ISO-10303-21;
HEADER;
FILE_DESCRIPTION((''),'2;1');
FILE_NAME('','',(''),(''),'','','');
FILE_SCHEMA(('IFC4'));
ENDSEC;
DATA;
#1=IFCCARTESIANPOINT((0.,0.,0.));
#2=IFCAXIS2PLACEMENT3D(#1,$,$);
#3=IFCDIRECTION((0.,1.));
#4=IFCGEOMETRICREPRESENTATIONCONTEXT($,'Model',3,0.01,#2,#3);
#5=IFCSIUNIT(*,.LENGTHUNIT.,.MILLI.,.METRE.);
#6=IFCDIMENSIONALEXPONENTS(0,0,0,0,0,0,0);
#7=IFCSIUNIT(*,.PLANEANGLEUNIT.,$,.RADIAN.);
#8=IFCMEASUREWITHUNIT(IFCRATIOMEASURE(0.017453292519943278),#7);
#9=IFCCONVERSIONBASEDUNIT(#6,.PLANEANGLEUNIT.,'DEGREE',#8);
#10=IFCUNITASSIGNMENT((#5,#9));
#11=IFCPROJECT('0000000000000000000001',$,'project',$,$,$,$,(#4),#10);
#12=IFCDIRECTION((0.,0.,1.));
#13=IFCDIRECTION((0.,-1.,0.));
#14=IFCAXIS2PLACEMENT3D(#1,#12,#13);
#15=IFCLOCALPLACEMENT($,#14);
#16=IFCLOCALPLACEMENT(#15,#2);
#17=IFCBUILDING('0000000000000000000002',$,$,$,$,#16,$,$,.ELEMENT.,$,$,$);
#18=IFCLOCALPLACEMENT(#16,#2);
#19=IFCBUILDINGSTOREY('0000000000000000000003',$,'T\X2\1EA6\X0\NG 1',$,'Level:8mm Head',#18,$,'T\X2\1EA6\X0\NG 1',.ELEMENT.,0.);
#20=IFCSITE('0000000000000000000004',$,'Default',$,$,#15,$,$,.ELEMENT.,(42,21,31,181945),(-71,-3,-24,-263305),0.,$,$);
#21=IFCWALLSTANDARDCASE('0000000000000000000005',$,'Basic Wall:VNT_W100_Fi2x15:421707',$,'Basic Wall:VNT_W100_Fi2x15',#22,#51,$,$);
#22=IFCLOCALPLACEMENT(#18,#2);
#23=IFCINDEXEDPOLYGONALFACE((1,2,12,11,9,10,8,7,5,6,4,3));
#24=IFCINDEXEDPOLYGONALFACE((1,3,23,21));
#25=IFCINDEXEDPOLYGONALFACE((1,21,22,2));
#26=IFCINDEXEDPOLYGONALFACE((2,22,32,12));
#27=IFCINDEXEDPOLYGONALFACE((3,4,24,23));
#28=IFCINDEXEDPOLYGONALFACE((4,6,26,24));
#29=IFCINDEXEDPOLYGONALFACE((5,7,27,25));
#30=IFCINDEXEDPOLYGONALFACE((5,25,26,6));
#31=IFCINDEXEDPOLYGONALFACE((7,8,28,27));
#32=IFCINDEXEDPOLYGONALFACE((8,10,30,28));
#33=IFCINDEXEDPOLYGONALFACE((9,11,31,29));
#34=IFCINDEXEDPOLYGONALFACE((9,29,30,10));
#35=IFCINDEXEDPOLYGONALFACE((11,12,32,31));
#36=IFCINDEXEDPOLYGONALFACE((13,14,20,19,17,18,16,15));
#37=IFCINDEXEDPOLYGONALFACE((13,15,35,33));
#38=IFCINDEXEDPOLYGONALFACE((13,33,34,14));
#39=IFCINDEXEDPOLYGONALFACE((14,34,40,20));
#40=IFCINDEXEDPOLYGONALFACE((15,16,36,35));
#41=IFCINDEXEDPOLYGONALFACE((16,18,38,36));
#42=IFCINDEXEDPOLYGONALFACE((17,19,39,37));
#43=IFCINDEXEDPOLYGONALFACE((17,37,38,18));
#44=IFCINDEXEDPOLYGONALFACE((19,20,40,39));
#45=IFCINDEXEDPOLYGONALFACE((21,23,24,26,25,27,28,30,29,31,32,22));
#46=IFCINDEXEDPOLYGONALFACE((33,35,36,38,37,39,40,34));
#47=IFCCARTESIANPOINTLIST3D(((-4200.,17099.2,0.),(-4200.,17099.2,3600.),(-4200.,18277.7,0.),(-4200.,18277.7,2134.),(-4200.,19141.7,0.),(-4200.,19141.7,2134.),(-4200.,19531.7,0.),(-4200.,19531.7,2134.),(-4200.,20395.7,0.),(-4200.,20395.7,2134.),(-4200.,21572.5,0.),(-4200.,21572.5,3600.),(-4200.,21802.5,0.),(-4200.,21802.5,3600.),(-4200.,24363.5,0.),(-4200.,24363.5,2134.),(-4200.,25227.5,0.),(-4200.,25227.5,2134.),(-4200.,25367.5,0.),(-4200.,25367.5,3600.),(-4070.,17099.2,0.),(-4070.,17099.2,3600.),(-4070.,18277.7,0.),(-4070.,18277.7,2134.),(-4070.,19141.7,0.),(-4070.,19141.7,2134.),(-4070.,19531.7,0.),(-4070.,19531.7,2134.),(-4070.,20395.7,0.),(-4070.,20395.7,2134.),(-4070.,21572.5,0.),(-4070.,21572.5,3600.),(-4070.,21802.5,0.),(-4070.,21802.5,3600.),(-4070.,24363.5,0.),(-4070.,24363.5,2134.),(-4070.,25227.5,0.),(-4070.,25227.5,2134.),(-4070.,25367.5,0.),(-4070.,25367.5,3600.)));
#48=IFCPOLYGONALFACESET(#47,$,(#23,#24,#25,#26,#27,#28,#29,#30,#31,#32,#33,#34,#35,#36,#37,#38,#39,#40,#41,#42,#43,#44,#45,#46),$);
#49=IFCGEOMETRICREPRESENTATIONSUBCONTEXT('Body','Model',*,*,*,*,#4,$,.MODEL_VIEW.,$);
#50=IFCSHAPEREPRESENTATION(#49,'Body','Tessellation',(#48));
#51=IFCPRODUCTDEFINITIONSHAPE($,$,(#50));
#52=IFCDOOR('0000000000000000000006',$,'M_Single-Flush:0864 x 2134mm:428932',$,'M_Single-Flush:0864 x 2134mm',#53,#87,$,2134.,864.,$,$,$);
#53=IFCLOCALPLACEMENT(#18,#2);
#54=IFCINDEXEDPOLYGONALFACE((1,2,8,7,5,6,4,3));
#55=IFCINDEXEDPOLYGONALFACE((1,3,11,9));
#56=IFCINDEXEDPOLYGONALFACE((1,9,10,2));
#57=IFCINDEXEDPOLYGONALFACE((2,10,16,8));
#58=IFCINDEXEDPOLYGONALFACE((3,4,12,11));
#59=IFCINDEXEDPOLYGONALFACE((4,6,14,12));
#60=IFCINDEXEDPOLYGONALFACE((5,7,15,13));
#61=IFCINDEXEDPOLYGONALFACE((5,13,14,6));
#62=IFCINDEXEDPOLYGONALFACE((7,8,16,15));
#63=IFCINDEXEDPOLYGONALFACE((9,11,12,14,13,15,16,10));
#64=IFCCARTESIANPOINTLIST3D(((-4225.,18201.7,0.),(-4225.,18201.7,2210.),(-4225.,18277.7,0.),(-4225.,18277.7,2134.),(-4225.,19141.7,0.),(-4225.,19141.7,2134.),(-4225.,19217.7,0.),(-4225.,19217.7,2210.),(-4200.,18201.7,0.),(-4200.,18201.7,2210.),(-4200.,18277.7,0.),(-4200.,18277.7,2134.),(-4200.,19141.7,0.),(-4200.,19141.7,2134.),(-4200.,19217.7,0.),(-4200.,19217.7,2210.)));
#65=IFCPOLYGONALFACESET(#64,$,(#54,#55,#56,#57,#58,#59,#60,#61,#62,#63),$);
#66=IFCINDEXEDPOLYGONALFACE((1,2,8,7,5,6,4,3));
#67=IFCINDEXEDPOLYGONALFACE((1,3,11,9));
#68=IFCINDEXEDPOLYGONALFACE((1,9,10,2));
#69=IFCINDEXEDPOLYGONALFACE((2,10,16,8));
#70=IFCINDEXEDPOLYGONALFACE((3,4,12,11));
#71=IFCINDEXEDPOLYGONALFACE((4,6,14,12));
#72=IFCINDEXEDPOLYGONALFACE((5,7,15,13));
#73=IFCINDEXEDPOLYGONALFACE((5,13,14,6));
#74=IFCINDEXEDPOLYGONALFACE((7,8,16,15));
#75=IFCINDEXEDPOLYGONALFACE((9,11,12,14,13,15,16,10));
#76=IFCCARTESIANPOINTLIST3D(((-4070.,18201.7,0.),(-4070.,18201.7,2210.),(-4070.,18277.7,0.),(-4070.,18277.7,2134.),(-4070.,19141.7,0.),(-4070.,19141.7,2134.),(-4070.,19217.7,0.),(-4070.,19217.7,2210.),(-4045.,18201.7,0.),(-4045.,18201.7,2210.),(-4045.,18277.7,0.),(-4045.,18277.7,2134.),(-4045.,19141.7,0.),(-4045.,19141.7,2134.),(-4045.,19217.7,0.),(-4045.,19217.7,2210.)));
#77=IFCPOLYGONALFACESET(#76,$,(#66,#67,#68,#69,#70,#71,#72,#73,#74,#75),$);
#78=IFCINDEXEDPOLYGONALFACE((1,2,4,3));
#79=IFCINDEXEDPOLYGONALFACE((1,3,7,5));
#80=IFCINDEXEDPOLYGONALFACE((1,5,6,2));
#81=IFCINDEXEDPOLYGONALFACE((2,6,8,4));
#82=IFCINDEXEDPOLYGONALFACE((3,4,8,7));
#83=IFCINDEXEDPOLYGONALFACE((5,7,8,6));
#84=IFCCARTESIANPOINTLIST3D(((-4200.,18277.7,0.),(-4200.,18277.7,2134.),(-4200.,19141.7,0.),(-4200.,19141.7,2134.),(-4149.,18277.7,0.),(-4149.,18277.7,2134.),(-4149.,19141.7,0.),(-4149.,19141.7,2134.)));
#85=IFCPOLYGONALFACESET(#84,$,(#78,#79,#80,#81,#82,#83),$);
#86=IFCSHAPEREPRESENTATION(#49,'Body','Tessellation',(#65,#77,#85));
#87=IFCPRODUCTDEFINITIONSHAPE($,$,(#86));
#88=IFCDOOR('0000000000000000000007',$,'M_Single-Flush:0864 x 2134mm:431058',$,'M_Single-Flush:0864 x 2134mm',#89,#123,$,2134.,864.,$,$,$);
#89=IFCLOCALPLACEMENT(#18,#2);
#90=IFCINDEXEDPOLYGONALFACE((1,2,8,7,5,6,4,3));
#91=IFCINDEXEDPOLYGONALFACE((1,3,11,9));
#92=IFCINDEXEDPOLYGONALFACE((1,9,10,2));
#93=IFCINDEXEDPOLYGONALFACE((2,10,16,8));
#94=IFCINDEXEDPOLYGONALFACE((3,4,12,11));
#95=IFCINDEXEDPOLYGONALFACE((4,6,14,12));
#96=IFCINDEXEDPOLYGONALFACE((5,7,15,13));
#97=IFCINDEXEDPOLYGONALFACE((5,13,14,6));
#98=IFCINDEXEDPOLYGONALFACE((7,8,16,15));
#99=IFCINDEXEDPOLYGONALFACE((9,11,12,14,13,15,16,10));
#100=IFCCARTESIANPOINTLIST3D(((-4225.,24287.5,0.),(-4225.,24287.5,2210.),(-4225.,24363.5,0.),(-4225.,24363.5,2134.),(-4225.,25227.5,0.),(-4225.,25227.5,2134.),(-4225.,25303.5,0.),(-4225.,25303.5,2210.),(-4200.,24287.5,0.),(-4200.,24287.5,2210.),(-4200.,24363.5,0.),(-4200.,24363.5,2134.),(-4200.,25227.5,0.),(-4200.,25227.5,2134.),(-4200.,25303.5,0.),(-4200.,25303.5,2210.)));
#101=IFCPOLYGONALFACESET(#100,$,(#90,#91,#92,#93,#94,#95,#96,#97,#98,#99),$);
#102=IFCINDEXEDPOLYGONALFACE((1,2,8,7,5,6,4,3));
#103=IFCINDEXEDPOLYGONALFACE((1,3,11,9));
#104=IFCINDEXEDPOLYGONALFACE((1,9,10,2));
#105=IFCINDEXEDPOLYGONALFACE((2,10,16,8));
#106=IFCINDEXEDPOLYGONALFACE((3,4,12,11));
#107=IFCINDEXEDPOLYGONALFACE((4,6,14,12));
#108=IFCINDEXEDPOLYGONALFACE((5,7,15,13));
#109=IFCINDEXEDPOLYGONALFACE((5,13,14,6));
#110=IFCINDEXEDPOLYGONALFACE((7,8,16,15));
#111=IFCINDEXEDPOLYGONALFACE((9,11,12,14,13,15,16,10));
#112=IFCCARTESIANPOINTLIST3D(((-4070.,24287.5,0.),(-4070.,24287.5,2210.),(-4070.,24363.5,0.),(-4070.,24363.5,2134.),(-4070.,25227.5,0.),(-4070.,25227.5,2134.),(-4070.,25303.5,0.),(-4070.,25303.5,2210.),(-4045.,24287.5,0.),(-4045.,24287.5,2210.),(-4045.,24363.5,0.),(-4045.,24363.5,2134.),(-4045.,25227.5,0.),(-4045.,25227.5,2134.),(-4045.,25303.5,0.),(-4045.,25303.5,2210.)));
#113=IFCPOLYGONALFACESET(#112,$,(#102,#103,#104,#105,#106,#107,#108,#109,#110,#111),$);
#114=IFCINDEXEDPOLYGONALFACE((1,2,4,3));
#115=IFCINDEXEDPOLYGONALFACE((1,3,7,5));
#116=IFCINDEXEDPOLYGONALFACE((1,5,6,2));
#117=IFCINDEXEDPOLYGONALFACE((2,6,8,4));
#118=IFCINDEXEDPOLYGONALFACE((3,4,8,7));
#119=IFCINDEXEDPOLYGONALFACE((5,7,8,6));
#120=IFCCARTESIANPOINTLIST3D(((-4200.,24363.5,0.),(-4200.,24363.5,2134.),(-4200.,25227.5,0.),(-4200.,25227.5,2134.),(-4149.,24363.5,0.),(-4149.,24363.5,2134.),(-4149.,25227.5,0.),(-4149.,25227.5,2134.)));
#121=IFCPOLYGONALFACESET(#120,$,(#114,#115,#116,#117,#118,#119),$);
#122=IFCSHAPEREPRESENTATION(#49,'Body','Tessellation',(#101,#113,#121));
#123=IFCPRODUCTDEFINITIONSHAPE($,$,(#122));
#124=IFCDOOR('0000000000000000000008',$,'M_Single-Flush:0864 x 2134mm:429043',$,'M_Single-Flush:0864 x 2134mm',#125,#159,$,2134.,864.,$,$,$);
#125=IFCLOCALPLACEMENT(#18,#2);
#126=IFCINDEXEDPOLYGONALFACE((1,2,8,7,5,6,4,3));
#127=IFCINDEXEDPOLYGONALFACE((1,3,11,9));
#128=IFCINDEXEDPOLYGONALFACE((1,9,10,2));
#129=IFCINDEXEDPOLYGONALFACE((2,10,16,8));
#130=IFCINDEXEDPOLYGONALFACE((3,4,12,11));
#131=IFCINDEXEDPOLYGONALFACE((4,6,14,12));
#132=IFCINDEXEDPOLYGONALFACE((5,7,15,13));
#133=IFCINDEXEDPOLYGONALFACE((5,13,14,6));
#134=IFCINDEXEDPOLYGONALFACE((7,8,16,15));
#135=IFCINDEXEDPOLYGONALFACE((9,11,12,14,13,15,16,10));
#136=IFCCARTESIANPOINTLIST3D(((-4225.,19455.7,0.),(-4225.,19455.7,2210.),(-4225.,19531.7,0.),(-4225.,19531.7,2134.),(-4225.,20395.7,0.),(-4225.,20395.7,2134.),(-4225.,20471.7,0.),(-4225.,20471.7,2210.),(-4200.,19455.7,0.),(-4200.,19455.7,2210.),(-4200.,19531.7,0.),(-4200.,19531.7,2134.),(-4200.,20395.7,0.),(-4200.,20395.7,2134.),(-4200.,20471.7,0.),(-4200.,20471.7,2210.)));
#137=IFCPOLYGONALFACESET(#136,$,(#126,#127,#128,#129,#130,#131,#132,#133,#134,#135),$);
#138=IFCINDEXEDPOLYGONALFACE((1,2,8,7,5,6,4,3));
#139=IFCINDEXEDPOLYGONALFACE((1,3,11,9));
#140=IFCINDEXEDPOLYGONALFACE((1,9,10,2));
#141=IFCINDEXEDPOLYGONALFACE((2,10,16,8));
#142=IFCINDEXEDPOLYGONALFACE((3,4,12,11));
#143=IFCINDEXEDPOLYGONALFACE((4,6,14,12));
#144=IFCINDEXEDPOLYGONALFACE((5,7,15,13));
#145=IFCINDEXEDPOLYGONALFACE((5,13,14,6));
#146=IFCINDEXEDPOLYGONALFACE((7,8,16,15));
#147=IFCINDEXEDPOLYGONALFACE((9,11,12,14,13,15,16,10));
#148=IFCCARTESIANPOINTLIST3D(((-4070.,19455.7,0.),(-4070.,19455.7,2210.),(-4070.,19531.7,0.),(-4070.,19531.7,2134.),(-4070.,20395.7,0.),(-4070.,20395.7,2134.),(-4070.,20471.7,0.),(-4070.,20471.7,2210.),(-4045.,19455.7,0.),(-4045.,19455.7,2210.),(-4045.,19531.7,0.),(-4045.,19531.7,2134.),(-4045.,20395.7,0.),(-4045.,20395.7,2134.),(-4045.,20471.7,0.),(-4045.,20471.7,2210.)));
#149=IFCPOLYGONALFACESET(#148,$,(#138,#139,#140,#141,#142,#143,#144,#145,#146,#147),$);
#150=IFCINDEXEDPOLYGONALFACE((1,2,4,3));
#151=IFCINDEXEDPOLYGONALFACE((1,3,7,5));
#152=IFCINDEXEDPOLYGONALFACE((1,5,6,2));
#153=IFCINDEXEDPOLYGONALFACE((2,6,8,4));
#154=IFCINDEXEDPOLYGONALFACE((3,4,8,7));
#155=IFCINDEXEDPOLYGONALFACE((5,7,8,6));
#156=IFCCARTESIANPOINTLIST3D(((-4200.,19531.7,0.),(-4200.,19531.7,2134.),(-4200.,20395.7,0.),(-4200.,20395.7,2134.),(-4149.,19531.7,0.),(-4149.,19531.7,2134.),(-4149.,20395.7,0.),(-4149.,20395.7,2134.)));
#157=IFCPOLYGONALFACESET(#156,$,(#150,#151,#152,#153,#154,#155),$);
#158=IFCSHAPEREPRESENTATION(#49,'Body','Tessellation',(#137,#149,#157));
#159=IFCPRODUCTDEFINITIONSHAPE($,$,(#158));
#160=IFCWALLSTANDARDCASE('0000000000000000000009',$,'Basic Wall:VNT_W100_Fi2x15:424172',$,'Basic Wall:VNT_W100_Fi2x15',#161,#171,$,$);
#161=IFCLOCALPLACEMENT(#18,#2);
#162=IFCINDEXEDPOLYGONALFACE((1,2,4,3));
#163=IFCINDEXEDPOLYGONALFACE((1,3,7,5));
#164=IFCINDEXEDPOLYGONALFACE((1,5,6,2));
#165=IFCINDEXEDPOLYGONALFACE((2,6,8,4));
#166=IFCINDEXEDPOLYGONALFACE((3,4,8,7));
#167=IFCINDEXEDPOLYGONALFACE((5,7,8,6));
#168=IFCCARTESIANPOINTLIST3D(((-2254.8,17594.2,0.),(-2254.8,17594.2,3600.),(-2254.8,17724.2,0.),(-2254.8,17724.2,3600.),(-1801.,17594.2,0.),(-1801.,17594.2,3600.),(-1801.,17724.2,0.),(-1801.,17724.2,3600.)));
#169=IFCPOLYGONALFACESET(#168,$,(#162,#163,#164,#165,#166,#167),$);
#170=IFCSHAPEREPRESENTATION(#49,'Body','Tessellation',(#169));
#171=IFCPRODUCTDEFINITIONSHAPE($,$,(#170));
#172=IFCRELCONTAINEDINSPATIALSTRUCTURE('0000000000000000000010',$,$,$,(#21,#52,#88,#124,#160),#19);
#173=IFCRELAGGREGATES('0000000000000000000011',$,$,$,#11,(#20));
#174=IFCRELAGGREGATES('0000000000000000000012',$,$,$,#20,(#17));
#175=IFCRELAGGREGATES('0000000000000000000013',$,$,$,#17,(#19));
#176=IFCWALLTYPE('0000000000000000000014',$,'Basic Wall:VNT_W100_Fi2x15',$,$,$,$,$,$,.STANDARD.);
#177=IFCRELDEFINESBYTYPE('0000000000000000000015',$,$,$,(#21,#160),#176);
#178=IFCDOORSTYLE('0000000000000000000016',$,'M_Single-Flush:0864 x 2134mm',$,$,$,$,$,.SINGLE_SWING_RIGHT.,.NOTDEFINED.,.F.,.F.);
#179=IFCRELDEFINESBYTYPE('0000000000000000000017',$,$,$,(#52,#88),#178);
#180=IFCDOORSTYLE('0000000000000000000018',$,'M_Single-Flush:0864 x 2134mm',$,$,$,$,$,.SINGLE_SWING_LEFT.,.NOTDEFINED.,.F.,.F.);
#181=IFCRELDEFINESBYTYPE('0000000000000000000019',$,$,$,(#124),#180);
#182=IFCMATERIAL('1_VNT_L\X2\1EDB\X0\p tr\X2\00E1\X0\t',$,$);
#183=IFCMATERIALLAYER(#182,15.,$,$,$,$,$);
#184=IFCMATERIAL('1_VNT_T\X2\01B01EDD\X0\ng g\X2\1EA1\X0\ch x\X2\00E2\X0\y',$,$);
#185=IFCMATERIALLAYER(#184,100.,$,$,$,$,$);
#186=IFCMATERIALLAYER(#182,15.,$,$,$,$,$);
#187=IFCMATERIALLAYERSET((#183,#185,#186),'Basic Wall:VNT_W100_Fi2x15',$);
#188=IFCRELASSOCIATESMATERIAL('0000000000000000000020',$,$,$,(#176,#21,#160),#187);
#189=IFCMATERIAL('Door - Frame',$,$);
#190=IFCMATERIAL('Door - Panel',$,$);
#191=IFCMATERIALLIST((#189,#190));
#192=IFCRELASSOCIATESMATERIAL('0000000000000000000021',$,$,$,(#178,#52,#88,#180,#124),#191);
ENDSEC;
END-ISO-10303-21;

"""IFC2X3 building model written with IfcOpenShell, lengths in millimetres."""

from ifc_helpers import new_model, entity, si_unit, converted_unit, direction, frame, frame_2d, origin, place, context, subcontext, project, spatial, polyline, rectangle, outline, extrude, source, transform, mapped, material, material_list, layer, layer_set, layer_usage, type_object, type_shapes, element, fill, save


model = new_model("IFC2X3")

# Units and contexts
model_context = context("Model", 3, precision=0.01, world=origin(), true_north=direction((0.0, 1.0)))
body_context = subcontext(model_context, "Body", "Model", "MODEL_VIEW")
ifc_project = project(units=[si_unit("LENGTHUNIT", "METRE", prefix="MILLI"), converted_unit("PLANEANGLEUNIT", "DEGREE", entity("IfcRatioMeasure", 0.017453292519943278), si_unit("PLANEANGLEUNIT", "RADIAN"), dimensions=[0, 0, 0, 0, 0, 0, 0])], contexts=[model_context])

# Site, building, storey
site_placement = place(None, frame((0.0, 0.0, 0.0), z_axis=(0.0, 0.0, 1.0), x_axis=(0.0, -1.0, 0.0)))
site = spatial("IfcSite", under=ifc_project, at=site_placement, Name="Default", CompositionType="ELEMENT", RefLatitude=(42, 21, 31, 181945), RefLongitude=(-71, -3, -24, -263305), RefElevation=0.0)
building_placement = place(site_placement, origin())
building = spatial("IfcBuilding", under=site, at=building_placement, CompositionType="ELEMENT")
storey_placement = place(building_placement, origin())
storey = spatial("IfcBuildingStorey", under=building, at=storey_placement, Name="TẦNG 1", ObjectType="Level:8mm Head", LongName="TẦNG 1", CompositionType="ELEMENT", Elevation=0.0)

# Shared definitions
ifc_material_1 = material(Name="1_VNT_Lớp trát")
ifc_material_2 = material(Name="1_VNT_Tường gạch xây")

# Shared definitions
ifc_layer_1 = layer(ifc_material_1, 15.0)
ifc_layer_2 = layer(ifc_material_2, 100.0)
ifc_layer_3 = layer(ifc_material_1, 15.0)
ifc_layer_set_1 = layer_set([ifc_layer_1, ifc_layer_2, ifc_layer_3], Name="Basic Wall:VNT_W100_Fi2x15")
ifc_layer_usage_1 = layer_usage(ifc_layer_set_1, "AXIS2", "NEGATIVE", 65.0)
wall_type_1 = type_object("IfcWallType", Name="Basic Wall:VNT_W100_Fi2x15", PredefinedType="STANDARD", material=ifc_layer_set_1)

# Wall, openings, doors
wall_1_placement = place(storey_placement, frame((-4135.0, 17099.2, 0.0), z_axis=(0.0, 0.0, 1.0), x_axis=(0.0, 1.0, 0.0)))
wall_1 = element("IfcWallStandardCase", 1, at=wall_1_placement, inside=storey, type_object=wall_type_1, material=ifc_layer_usage_1, Name="Basic Wall:VNT_W100_Fi2x15:421707", ObjectType="Basic Wall:VNT_W100_Fi2x15", context=body_context, shape_type="SweptSolid", body=[
    extrude(rectangle(XDim=8268.3, YDim=130.0, at=frame_2d((4134.1, 0.0), x_axis=(-1.0, 0.0))), origin(), (0.0, 0.0, 1.0), 3600.0),
])
opening_1_placement = place(storey_placement, frame((-4135.0, 17099.2, 0.0), z_axis=(0.0, 0.0, 1.0), x_axis=(0.0, 1.0, 0.0)))
element("IfcOpeningElement", 2, at=opening_1_placement, cuts=wall_1, ObjectType="Opening", context=body_context, shape_type="SweptSolid", body=[
    extrude(rectangle(XDim=3600.0, YDim=130.0, at=frame_2d((0.0, 0.0), x_axis=(1.0, 0.0))), frame((4473.3, 0.0, 1800.0), z_axis=(1.0, 0.0, 0.0), x_axis=(0.0, 0.0, -1.0)), (0.0, 0.0, 1.0), 230.0),
])
opening_2_placement = place(wall_1_placement, frame((1178.5, -65.0, 0.0)))
opening_2 = element("IfcOpeningElement", 3, at=opening_2_placement, cuts=wall_1, ObjectType="Opening", context=body_context, shape_type="SweptSolid", body=[
    extrude(rectangle(XDim=864.0, YDim=2134.0, at=frame_2d((1067.0, 432.0), x_axis=(0.0, 1.0))), frame((0.0, 0.0, 0.0), z_axis=(0.0, 1.0, 0.0), x_axis=(0.0, 0.0, 1.0)), (0.0, 0.0, 1.0), 130.0),
])
opening_3_placement = place(wall_1_placement, frame((2432.5, -65.0, 0.0)))
opening_3 = element("IfcOpeningElement", 4, at=opening_3_placement, cuts=wall_1, ObjectType="Opening", context=body_context, shape_type="SweptSolid", body=[
    extrude(rectangle(XDim=864.0, YDim=2134.0, at=frame_2d((1067.0, 432.0), x_axis=(0.0, -1.0))), frame((0.0, 0.0, 0.0), z_axis=(0.0, 1.0, 0.0), x_axis=(0.0, 0.0, 1.0)), (0.0, 0.0, 1.0), 130.0),
])
opening_4_placement = place(wall_1_placement, frame((7264.3, -65.0, 0.0)))
opening_4 = element("IfcOpeningElement", 5, at=opening_4_placement, cuts=wall_1, ObjectType="Opening", context=body_context, shape_type="SweptSolid", body=[
    extrude(rectangle(XDim=864.0, YDim=2134.0, at=frame_2d((1067.0, 432.0), x_axis=(0.0, 1.0))), frame((0.0, 0.0, 0.0), z_axis=(0.0, 1.0, 0.0), x_axis=(0.0, 0.0, 1.0)), (0.0, 0.0, 1.0), 130.0),
])
ifc_material_3 = material(Name="Door - Frame")
ifc_material_4 = material(Name="Door - Panel")
ifc_material_list = material_list([ifc_material_3, ifc_material_4])
door_style_1 = type_object("IfcDoorStyle", Name="M_Single-Flush:0864 x 2134mm", ConstructionType="NOTDEFINED", OperationType="SINGLE_SWING_RIGHT", ParameterTakesPrecedence=False, Sizeable=False, material=ifc_material_list)
shared_shape_1 = source(origin(), body_context, "Body", "SweptSolid", [
    extrude(outline(polyline([(-508.0, -1124.0), (508.0, -1124.0), (508.0, 1086.0), (432.0, 1086.0), (432.0, -1048.0), (-432.0, -1048.0), (-432.0, 1086.0), (-508.0, 1086.0), (-508.0, -1124.0)])), frame((432.0, 130.0, 1086.0), z_axis=(0.0, 1.0, 0.0), x_axis=(1.0, 0.0, 0.0)), (0.0, 0.0, 1.0), 25.0),
    extrude(outline(polyline([(-1124.0, -508.0), (1086.0, -508.0), (1086.0, -432.0), (-1048.0, -432.0), (-1048.0, 432.0), (1086.0, 432.0), (1086.0, 508.0), (-1124.0, 508.0), (-1124.0, -508.0)])), frame((432.0, -25.0, 1086.0), z_axis=(0.0, 1.0, 0.0), x_axis=(0.0, 0.0, -1.0)), (0.0, 0.0, 1.0), 25.0),
    extrude(rectangle(XDim=51.0, YDim=864.0, at=frame_2d((0.0, 0.0), x_axis=(1.0, 0.0))), frame((432.0, 104.5, 0.0), z_axis=(0.0, 0.0, 1.0), x_axis=(0.0, 1.0, 0.0)), (0.0, 0.0, 1.0), 2134.0),
])
type_shapes(door_style_1, [shared_shape_1])
door_1_placement = place(opening_2_placement, origin())
door_1 = element("IfcDoor", 6, at=door_1_placement, inside=storey, type_object=door_style_1, material=ifc_material_list, Name="M_Single-Flush:0864 x 2134mm:428932", ObjectType="M_Single-Flush:0864 x 2134mm", OverallHeight=2134.0, OverallWidth=864.0, context=body_context, shape_type="MappedRepresentation", body=[
    mapped(shared_shape_1, transform((0.0, 0.0, 0.0), scale=1.0)),
])
fill(opening_2, door_1)
door_2_placement = place(opening_4_placement, origin())
door_2 = element("IfcDoor", 7, at=door_2_placement, inside=storey, type_object=door_style_1, material=ifc_material_list, Name="M_Single-Flush:0864 x 2134mm:431058", ObjectType="M_Single-Flush:0864 x 2134mm", OverallHeight=2134.0, OverallWidth=864.0, context=body_context, shape_type="MappedRepresentation", body=[
    mapped(shared_shape_1, transform((0.0, 0.0, 0.0), scale=1.0)),
])
fill(opening_4, door_2)
door_style_2 = type_object("IfcDoorStyle", Name="M_Single-Flush:0864 x 2134mm", ConstructionType="NOTDEFINED", OperationType="SINGLE_SWING_LEFT", ParameterTakesPrecedence=False, Sizeable=False, material=ifc_material_list)
shared_shape_2 = source(origin(), body_context, "Body", "SweptSolid", [
    extrude(outline(polyline([(-508.0, -1124.0), (508.0, -1124.0), (508.0, 1086.0), (432.0, 1086.0), (432.0, -1048.0), (-432.0, -1048.0), (-432.0, 1086.0), (-508.0, 1086.0), (-508.0, -1124.0)])), frame((432.0, 155.0, 1086.0), z_axis=(0.0, -1.0, 0.0), x_axis=(-1.0, 0.0, 0.0)), (0.0, 0.0, 1.0), 25.0),
    extrude(outline(polyline([(-1124.0, -508.0), (1086.0, -508.0), (1086.0, -432.0), (-1048.0, -432.0), (-1048.0, 432.0), (1086.0, 432.0), (1086.0, 508.0), (-1124.0, 508.0), (-1124.0, -508.0)])), frame((432.0, 0.0, 1086.0), z_axis=(0.0, -1.0, 0.0), x_axis=(0.0, 0.0, -1.0)), (0.0, 0.0, 1.0), 25.0),
    extrude(rectangle(XDim=864.0, YDim=51.0, at=frame_2d((0.0, 0.0), x_axis=(1.0, 0.0))), frame((432.0, 104.5, 0.0)), (0.0, 0.0, 1.0), 2134.0),
])
type_shapes(door_style_2, [shared_shape_2])
door_3_placement = place(opening_3_placement, origin())
door_3 = element("IfcDoor", 8, at=door_3_placement, inside=storey, type_object=door_style_2, material=ifc_material_list, Name="M_Single-Flush:0864 x 2134mm:429043", ObjectType="M_Single-Flush:0864 x 2134mm", OverallHeight=2134.0, OverallWidth=864.0, context=body_context, shape_type="MappedRepresentation", body=[
    mapped(shared_shape_2, transform((0.0, 0.0, 0.0), scale=1.0)),
])
fill(opening_3, door_3)

# Wall
wall_2_placement = place(storey_placement, frame((-1801.0, 17659.2, 0.0), z_axis=(0.0, 0.0, 1.0), x_axis=(-1.0, 0.0, 0.0)))
element("IfcWallStandardCase", 9, at=wall_2_placement, inside=storey, type_object=wall_type_1, material=ifc_layer_usage_1, Name="Basic Wall:VNT_W100_Fi2x15:424172", ObjectType="Basic Wall:VNT_W100_Fi2x15", context=body_context, shape_type="SweptSolid", body=[
    extrude(rectangle(XDim=453.8, YDim=130.0, at=frame_2d((226.9, 0.0), x_axis=(-1.0, 0.0))), origin(), (0.0, 0.0, 1.0), 3600.0),
])

save(model, "model.ifc")
